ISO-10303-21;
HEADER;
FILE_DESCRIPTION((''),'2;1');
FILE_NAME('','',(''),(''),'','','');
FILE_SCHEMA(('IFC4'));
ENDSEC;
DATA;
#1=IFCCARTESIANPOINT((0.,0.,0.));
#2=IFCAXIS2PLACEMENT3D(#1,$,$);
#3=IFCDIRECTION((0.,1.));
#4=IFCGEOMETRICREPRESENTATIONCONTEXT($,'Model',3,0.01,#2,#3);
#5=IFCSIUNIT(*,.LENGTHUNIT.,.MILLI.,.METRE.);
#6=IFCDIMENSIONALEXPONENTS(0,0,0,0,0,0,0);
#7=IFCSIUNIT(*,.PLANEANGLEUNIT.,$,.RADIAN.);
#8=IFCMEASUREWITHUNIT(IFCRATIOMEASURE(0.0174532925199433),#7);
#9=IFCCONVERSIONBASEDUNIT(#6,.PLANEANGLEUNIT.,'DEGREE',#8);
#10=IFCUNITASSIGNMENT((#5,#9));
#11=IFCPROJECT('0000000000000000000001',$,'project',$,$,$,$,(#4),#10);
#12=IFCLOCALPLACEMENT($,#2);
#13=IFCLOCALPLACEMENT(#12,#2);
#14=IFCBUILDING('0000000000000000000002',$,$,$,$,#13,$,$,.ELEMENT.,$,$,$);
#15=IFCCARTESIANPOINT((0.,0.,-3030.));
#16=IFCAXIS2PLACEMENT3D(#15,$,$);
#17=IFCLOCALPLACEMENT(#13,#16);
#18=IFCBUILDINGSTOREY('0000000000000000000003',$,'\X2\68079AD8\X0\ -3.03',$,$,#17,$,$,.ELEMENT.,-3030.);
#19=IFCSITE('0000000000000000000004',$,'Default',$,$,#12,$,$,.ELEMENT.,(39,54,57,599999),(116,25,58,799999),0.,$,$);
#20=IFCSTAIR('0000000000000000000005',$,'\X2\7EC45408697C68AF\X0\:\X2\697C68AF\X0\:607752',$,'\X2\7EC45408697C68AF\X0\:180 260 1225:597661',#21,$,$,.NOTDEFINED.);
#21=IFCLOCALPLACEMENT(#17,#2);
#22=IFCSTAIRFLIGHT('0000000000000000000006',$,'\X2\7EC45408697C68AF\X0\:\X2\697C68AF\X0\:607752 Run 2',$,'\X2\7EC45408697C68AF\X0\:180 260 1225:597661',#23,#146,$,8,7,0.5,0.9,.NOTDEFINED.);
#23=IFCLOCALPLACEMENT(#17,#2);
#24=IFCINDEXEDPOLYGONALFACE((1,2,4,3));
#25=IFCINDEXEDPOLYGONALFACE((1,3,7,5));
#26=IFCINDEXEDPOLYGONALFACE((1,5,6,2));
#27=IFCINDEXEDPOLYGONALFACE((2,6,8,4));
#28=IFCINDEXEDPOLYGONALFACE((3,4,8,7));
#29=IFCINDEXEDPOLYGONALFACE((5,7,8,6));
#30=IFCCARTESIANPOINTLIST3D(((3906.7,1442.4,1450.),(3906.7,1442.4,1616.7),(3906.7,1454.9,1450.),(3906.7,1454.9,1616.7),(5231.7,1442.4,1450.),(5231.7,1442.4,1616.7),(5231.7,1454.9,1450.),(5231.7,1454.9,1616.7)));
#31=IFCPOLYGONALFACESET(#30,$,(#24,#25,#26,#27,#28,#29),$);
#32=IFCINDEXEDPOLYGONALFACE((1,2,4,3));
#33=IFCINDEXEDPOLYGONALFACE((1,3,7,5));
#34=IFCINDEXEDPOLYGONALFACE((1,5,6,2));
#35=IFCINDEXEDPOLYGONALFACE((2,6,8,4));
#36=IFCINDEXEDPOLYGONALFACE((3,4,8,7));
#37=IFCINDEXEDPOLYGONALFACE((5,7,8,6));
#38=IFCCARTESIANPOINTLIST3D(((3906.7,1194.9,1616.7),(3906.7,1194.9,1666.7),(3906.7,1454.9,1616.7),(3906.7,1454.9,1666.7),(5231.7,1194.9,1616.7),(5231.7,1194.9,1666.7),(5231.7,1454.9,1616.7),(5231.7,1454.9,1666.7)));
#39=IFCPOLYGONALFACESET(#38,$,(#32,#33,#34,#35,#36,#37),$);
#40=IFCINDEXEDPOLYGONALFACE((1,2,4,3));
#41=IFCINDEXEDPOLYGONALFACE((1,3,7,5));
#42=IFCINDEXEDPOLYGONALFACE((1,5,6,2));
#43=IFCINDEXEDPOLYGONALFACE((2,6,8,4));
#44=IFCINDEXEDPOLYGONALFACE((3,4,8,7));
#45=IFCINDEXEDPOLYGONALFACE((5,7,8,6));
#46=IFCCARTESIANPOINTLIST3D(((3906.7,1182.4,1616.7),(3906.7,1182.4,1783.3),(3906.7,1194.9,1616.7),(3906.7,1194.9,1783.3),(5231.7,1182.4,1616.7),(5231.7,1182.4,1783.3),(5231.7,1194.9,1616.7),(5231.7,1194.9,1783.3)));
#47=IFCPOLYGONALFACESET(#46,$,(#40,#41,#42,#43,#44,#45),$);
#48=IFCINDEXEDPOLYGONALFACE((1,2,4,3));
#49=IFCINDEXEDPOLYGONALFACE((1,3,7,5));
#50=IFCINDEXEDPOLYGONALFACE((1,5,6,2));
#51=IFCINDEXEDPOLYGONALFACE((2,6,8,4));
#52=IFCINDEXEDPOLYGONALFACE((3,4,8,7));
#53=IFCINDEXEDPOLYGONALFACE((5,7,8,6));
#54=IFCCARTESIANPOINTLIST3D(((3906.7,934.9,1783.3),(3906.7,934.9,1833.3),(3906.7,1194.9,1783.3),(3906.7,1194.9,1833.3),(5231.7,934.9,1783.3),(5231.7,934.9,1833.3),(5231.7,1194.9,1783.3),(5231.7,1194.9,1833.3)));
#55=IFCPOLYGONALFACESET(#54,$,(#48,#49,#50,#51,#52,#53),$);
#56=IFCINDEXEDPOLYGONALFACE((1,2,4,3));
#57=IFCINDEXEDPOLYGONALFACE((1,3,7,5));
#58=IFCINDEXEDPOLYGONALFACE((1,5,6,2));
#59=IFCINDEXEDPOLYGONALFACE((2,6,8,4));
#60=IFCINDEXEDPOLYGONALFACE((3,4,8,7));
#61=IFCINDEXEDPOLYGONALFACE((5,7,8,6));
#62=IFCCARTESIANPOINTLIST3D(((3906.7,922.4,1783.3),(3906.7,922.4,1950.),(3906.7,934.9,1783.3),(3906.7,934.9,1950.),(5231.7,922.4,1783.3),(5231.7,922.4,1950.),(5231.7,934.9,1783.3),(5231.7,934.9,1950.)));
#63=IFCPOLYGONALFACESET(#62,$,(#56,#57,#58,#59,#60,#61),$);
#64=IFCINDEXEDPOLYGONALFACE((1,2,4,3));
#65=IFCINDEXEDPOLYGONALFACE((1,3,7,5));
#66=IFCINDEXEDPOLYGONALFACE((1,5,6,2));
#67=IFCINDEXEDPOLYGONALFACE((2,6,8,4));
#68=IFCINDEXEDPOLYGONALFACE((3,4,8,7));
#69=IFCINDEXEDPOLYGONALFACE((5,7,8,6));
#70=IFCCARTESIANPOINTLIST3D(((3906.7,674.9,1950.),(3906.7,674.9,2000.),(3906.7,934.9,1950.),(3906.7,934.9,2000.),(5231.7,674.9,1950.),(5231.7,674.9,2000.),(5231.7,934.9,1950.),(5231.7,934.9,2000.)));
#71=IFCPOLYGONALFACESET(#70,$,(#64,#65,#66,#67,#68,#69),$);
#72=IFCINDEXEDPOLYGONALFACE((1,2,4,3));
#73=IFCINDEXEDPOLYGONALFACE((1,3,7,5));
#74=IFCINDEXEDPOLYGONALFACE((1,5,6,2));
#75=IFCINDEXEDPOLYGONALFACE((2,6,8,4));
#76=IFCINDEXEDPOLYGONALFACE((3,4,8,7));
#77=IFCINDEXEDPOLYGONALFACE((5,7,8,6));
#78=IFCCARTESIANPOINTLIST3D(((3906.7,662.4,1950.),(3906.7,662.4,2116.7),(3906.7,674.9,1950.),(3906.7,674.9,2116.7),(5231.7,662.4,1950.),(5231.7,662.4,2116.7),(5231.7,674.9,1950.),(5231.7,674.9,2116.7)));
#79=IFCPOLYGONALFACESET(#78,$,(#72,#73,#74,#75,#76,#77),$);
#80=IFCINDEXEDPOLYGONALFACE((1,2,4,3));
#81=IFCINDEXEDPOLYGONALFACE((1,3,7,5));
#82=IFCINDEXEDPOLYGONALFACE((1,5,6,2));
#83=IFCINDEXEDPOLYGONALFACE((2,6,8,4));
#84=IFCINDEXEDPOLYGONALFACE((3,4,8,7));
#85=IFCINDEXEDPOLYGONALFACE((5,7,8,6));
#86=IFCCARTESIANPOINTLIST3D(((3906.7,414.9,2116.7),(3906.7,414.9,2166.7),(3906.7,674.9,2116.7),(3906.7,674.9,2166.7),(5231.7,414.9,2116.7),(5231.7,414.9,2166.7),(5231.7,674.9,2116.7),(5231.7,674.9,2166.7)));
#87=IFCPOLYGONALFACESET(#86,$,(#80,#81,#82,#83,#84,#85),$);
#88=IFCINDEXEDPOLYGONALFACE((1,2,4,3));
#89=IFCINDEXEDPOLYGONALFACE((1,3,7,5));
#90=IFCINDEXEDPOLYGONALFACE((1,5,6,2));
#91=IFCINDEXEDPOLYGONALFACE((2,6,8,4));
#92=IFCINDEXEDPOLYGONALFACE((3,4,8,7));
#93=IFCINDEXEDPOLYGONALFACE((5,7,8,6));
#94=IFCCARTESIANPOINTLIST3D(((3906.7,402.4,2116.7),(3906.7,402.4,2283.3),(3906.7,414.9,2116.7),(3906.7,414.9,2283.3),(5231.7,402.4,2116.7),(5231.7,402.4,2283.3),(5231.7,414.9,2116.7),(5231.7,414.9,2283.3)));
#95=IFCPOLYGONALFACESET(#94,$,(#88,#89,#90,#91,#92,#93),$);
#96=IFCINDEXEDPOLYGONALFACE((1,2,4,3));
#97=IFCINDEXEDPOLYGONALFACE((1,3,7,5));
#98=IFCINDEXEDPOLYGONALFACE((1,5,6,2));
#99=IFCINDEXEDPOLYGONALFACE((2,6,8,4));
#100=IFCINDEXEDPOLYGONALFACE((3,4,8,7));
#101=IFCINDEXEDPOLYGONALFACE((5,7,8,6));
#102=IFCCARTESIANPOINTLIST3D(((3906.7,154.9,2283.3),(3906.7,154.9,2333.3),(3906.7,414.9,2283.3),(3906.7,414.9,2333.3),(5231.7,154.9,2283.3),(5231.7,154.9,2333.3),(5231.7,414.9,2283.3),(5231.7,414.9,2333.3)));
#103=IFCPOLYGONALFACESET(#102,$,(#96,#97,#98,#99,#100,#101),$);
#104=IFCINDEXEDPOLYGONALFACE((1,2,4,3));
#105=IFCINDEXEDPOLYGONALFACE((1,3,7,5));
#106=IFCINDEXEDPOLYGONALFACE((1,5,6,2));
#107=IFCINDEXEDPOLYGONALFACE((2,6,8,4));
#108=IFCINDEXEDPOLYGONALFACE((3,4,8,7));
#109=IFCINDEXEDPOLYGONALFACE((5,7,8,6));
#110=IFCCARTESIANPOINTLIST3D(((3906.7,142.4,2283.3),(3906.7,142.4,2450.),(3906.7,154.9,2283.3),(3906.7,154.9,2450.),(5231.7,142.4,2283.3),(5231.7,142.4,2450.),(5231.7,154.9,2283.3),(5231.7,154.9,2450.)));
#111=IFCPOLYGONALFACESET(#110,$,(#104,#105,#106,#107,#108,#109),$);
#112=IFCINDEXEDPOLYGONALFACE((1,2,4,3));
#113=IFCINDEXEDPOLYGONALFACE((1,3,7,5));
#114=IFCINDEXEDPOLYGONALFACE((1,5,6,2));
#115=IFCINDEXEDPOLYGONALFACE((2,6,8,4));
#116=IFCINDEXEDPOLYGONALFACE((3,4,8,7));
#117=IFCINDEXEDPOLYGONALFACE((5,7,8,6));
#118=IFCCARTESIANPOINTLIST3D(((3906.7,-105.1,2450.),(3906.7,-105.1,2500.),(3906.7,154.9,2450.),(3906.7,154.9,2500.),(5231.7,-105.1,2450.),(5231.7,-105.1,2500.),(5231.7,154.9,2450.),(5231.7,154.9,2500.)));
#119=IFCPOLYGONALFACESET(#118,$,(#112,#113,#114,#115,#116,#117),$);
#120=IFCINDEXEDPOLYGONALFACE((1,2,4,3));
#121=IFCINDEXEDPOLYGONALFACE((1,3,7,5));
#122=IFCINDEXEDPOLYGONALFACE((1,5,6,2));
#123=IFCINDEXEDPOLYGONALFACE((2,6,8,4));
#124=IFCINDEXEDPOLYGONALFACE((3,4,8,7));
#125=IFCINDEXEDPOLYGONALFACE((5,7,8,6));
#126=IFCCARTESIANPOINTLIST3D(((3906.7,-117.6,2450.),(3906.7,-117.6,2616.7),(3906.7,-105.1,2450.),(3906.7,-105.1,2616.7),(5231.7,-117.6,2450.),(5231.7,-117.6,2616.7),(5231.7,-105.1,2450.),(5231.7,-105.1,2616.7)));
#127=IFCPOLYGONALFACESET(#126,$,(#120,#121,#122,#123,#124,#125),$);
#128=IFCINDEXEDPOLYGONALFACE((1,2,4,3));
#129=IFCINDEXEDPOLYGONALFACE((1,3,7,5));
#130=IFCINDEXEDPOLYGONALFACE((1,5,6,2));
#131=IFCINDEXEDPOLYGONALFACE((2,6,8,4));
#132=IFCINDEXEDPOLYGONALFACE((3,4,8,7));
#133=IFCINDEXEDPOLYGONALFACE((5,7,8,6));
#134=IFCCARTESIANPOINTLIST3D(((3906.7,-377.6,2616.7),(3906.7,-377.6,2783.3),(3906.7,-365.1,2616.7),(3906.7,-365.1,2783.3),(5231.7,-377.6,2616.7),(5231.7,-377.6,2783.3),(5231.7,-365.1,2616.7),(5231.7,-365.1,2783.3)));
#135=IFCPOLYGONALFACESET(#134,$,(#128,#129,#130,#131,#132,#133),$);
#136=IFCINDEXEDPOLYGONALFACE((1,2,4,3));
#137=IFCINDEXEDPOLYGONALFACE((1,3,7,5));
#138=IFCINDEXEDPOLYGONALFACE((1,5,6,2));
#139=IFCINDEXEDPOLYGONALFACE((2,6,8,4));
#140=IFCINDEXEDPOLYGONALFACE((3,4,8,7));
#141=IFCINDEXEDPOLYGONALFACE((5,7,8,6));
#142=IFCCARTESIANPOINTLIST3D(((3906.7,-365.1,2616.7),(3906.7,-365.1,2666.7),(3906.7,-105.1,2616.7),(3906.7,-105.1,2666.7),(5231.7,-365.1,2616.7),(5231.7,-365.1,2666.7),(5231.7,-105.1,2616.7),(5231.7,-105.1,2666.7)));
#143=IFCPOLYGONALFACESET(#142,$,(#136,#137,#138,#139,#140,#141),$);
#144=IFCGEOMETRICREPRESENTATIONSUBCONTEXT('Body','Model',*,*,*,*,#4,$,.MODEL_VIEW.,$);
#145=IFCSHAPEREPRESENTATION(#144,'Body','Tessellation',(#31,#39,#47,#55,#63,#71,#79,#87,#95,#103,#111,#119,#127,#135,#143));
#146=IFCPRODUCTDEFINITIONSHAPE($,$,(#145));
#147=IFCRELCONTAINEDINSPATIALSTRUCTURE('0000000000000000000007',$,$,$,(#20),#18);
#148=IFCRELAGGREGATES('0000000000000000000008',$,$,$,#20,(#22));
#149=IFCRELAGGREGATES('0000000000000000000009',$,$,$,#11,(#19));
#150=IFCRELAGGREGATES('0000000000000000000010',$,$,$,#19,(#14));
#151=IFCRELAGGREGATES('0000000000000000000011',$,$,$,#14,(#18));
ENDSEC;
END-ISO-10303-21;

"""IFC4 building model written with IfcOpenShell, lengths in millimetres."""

from ifc_helpers import new_model, entity, si_unit, converted_unit, direction, frame, frame_2d, origin, origin_2d_with_axis, place, context, subcontext, project, spatial, rectangle, extrude, element, aggregate, save


model = new_model("IFC4")

# Units and contexts
model_context = context("Model", 3, precision=0.01, world=origin(), true_north=direction((0.0, 1.0)))
body_context = subcontext(model_context, "Body", "Model", "MODEL_VIEW")
ifc_project = project(units=[si_unit("LENGTHUNIT", "METRE", prefix="MILLI"), converted_unit("PLANEANGLEUNIT", "DEGREE", entity("IfcRatioMeasure", 0.0174532925199433), si_unit("PLANEANGLEUNIT", "RADIAN"), dimensions=[0, 0, 0, 0, 0, 0, 0])], contexts=[model_context])

# Site, building, storey
site_placement = place(None, origin())
site = spatial("IfcSite", under=ifc_project, at=site_placement, Name="Default", CompositionType="ELEMENT", RefLatitude=(39, 54, 57, 599999), RefLongitude=(116, 25, 58, 799999), RefElevation=0.0)
building_placement = place(site_placement, origin())
building = spatial("IfcBuilding", under=site, at=building_placement, CompositionType="ELEMENT")
storey_placement = place(building_placement, frame((0.0, 0.0, -3030.0)))
storey = spatial("IfcBuildingStorey", under=building, at=storey_placement, Name="标高 -3.03", CompositionType="ELEMENT", Elevation=-3030.0)

# Stair, stair flight
stair_placement = place(storey_placement, origin())
stair = element("IfcStair", 1, at=stair_placement, inside=storey, Name="组合楼梯:楼梯:607752", ObjectType="组合楼梯:180 260 1225:597661", PredefinedType="NOTDEFINED")
stair_flight_1_placement = place(stair_placement, frame((3906.7, -377.6, 0.0)))
stair_flight_1 = element("IfcStairFlight", 2, at=stair_flight_1_placement, Name="组合楼梯:楼梯:607752 Run 2", ObjectType="组合楼梯:180 260 1225:597661", NumberOfRisers=8, NumberOfTreads=7, PredefinedType="NOTDEFINED", RiserHeight=0.5, TreadLength=0.9, context=body_context, shape_type="SweptSolid", body=[
    extrude(rectangle(XDim=1325.0, YDim=12.5, at=origin_2d_with_axis()), frame((662.5, 1826.2, 1450.0)), (0.0, 0.0, 1.0), 166.7),
    extrude(rectangle(XDim=260.0, YDim=1325.0, at=frame_2d((0.0, 0.0), x_axis=(1.0, 0.0))), frame((662.5, 1702.5, 1616.7), z_axis=(0.0, 0.0, 1.0), x_axis=(0.0, 1.0, 0.0)), (0.0, 0.0, 1.0), 50.0),
    extrude(rectangle(XDim=1325.0, YDim=12.5, at=origin_2d_with_axis()), frame((662.5, 1566.2, 1616.7)), (0.0, 0.0, 1.0), 166.7),
    extrude(rectangle(XDim=260.0, YDim=1325.0, at=frame_2d((0.0, 0.0), x_axis=(1.0, 0.0))), frame((662.5, 1442.5, 1783.3), z_axis=(0.0, 0.0, 1.0), x_axis=(0.0, 1.0, 0.0)), (0.0, 0.0, 1.0), 50.0),
    extrude(rectangle(XDim=1325.0, YDim=12.5, at=origin_2d_with_axis()), frame((662.5, 1306.2, 1783.3)), (0.0, 0.0, 1.0), 166.7),
    extrude(rectangle(XDim=260.0, YDim=1325.0, at=frame_2d((0.0, 0.0), x_axis=(1.0, 0.0))), frame((662.5, 1182.5, 1950.0), z_axis=(0.0, 0.0, 1.0), x_axis=(0.0, 1.0, 0.0)), (0.0, 0.0, 1.0), 50.0),
    extrude(rectangle(XDim=1325.0, YDim=12.5, at=origin_2d_with_axis()), frame((662.5, 1046.2, 1950.0)), (0.0, 0.0, 1.0), 166.7),
    extrude(rectangle(XDim=260.0, YDim=1325.0, at=frame_2d((0.0, 0.0), x_axis=(1.0, 0.0))), frame((662.5, 922.5, 2116.7), z_axis=(0.0, 0.0, 1.0), x_axis=(0.0, 1.0, 0.0)), (0.0, 0.0, 1.0), 50.0),
    extrude(rectangle(XDim=1325.0, YDim=12.5, at=origin_2d_with_axis()), frame((662.5, 786.2, 2116.7)), (0.0, 0.0, 1.0), 166.7),
    extrude(rectangle(XDim=260.0, YDim=1325.0, at=frame_2d((0.0, 0.0), x_axis=(1.0, 0.0))), frame((662.5, 662.5, 2283.3), z_axis=(0.0, 0.0, 1.0), x_axis=(0.0, 1.0, 0.0)), (0.0, 0.0, 1.0), 50.0),
    extrude(rectangle(XDim=1325.0, YDim=12.5, at=origin_2d_with_axis()), frame((662.5, 526.3, 2283.3)), (0.0, 0.0, 1.0), 166.7),
    extrude(rectangle(XDim=260.0, YDim=1325.0, at=frame_2d((0.0, 0.0), x_axis=(1.0, 0.0))), frame((662.5, 402.5, 2450.0), z_axis=(0.0, 0.0, 1.0), x_axis=(0.0, 1.0, 0.0)), (0.0, 0.0, 1.0), 50.0),
    extrude(rectangle(XDim=1325.0, YDim=12.5, at=origin_2d_with_axis()), frame((662.5, 266.3, 2450.0)), (0.0, 0.0, 1.0), 166.7),
    extrude(rectangle(XDim=1325.0, YDim=12.5, at=frame_2d((0.0, 0.0), x_axis=(1.0, 0.0))), frame((662.5, 6.2, 2616.7)), (0.0, 0.0, 1.0), 166.7),
    extrude(rectangle(XDim=260.0, YDim=1325.0, at=frame_2d((0.0, 0.0), x_axis=(1.0, 0.0))), frame((662.5, 142.5, 2616.7), z_axis=(0.0, 0.0, 1.0), x_axis=(0.0, 1.0, 0.0)), (0.0, 0.0, 1.0), 50.0),
])
aggregate(stair, [stair_flight_1])

save(model, "model.ifc")
